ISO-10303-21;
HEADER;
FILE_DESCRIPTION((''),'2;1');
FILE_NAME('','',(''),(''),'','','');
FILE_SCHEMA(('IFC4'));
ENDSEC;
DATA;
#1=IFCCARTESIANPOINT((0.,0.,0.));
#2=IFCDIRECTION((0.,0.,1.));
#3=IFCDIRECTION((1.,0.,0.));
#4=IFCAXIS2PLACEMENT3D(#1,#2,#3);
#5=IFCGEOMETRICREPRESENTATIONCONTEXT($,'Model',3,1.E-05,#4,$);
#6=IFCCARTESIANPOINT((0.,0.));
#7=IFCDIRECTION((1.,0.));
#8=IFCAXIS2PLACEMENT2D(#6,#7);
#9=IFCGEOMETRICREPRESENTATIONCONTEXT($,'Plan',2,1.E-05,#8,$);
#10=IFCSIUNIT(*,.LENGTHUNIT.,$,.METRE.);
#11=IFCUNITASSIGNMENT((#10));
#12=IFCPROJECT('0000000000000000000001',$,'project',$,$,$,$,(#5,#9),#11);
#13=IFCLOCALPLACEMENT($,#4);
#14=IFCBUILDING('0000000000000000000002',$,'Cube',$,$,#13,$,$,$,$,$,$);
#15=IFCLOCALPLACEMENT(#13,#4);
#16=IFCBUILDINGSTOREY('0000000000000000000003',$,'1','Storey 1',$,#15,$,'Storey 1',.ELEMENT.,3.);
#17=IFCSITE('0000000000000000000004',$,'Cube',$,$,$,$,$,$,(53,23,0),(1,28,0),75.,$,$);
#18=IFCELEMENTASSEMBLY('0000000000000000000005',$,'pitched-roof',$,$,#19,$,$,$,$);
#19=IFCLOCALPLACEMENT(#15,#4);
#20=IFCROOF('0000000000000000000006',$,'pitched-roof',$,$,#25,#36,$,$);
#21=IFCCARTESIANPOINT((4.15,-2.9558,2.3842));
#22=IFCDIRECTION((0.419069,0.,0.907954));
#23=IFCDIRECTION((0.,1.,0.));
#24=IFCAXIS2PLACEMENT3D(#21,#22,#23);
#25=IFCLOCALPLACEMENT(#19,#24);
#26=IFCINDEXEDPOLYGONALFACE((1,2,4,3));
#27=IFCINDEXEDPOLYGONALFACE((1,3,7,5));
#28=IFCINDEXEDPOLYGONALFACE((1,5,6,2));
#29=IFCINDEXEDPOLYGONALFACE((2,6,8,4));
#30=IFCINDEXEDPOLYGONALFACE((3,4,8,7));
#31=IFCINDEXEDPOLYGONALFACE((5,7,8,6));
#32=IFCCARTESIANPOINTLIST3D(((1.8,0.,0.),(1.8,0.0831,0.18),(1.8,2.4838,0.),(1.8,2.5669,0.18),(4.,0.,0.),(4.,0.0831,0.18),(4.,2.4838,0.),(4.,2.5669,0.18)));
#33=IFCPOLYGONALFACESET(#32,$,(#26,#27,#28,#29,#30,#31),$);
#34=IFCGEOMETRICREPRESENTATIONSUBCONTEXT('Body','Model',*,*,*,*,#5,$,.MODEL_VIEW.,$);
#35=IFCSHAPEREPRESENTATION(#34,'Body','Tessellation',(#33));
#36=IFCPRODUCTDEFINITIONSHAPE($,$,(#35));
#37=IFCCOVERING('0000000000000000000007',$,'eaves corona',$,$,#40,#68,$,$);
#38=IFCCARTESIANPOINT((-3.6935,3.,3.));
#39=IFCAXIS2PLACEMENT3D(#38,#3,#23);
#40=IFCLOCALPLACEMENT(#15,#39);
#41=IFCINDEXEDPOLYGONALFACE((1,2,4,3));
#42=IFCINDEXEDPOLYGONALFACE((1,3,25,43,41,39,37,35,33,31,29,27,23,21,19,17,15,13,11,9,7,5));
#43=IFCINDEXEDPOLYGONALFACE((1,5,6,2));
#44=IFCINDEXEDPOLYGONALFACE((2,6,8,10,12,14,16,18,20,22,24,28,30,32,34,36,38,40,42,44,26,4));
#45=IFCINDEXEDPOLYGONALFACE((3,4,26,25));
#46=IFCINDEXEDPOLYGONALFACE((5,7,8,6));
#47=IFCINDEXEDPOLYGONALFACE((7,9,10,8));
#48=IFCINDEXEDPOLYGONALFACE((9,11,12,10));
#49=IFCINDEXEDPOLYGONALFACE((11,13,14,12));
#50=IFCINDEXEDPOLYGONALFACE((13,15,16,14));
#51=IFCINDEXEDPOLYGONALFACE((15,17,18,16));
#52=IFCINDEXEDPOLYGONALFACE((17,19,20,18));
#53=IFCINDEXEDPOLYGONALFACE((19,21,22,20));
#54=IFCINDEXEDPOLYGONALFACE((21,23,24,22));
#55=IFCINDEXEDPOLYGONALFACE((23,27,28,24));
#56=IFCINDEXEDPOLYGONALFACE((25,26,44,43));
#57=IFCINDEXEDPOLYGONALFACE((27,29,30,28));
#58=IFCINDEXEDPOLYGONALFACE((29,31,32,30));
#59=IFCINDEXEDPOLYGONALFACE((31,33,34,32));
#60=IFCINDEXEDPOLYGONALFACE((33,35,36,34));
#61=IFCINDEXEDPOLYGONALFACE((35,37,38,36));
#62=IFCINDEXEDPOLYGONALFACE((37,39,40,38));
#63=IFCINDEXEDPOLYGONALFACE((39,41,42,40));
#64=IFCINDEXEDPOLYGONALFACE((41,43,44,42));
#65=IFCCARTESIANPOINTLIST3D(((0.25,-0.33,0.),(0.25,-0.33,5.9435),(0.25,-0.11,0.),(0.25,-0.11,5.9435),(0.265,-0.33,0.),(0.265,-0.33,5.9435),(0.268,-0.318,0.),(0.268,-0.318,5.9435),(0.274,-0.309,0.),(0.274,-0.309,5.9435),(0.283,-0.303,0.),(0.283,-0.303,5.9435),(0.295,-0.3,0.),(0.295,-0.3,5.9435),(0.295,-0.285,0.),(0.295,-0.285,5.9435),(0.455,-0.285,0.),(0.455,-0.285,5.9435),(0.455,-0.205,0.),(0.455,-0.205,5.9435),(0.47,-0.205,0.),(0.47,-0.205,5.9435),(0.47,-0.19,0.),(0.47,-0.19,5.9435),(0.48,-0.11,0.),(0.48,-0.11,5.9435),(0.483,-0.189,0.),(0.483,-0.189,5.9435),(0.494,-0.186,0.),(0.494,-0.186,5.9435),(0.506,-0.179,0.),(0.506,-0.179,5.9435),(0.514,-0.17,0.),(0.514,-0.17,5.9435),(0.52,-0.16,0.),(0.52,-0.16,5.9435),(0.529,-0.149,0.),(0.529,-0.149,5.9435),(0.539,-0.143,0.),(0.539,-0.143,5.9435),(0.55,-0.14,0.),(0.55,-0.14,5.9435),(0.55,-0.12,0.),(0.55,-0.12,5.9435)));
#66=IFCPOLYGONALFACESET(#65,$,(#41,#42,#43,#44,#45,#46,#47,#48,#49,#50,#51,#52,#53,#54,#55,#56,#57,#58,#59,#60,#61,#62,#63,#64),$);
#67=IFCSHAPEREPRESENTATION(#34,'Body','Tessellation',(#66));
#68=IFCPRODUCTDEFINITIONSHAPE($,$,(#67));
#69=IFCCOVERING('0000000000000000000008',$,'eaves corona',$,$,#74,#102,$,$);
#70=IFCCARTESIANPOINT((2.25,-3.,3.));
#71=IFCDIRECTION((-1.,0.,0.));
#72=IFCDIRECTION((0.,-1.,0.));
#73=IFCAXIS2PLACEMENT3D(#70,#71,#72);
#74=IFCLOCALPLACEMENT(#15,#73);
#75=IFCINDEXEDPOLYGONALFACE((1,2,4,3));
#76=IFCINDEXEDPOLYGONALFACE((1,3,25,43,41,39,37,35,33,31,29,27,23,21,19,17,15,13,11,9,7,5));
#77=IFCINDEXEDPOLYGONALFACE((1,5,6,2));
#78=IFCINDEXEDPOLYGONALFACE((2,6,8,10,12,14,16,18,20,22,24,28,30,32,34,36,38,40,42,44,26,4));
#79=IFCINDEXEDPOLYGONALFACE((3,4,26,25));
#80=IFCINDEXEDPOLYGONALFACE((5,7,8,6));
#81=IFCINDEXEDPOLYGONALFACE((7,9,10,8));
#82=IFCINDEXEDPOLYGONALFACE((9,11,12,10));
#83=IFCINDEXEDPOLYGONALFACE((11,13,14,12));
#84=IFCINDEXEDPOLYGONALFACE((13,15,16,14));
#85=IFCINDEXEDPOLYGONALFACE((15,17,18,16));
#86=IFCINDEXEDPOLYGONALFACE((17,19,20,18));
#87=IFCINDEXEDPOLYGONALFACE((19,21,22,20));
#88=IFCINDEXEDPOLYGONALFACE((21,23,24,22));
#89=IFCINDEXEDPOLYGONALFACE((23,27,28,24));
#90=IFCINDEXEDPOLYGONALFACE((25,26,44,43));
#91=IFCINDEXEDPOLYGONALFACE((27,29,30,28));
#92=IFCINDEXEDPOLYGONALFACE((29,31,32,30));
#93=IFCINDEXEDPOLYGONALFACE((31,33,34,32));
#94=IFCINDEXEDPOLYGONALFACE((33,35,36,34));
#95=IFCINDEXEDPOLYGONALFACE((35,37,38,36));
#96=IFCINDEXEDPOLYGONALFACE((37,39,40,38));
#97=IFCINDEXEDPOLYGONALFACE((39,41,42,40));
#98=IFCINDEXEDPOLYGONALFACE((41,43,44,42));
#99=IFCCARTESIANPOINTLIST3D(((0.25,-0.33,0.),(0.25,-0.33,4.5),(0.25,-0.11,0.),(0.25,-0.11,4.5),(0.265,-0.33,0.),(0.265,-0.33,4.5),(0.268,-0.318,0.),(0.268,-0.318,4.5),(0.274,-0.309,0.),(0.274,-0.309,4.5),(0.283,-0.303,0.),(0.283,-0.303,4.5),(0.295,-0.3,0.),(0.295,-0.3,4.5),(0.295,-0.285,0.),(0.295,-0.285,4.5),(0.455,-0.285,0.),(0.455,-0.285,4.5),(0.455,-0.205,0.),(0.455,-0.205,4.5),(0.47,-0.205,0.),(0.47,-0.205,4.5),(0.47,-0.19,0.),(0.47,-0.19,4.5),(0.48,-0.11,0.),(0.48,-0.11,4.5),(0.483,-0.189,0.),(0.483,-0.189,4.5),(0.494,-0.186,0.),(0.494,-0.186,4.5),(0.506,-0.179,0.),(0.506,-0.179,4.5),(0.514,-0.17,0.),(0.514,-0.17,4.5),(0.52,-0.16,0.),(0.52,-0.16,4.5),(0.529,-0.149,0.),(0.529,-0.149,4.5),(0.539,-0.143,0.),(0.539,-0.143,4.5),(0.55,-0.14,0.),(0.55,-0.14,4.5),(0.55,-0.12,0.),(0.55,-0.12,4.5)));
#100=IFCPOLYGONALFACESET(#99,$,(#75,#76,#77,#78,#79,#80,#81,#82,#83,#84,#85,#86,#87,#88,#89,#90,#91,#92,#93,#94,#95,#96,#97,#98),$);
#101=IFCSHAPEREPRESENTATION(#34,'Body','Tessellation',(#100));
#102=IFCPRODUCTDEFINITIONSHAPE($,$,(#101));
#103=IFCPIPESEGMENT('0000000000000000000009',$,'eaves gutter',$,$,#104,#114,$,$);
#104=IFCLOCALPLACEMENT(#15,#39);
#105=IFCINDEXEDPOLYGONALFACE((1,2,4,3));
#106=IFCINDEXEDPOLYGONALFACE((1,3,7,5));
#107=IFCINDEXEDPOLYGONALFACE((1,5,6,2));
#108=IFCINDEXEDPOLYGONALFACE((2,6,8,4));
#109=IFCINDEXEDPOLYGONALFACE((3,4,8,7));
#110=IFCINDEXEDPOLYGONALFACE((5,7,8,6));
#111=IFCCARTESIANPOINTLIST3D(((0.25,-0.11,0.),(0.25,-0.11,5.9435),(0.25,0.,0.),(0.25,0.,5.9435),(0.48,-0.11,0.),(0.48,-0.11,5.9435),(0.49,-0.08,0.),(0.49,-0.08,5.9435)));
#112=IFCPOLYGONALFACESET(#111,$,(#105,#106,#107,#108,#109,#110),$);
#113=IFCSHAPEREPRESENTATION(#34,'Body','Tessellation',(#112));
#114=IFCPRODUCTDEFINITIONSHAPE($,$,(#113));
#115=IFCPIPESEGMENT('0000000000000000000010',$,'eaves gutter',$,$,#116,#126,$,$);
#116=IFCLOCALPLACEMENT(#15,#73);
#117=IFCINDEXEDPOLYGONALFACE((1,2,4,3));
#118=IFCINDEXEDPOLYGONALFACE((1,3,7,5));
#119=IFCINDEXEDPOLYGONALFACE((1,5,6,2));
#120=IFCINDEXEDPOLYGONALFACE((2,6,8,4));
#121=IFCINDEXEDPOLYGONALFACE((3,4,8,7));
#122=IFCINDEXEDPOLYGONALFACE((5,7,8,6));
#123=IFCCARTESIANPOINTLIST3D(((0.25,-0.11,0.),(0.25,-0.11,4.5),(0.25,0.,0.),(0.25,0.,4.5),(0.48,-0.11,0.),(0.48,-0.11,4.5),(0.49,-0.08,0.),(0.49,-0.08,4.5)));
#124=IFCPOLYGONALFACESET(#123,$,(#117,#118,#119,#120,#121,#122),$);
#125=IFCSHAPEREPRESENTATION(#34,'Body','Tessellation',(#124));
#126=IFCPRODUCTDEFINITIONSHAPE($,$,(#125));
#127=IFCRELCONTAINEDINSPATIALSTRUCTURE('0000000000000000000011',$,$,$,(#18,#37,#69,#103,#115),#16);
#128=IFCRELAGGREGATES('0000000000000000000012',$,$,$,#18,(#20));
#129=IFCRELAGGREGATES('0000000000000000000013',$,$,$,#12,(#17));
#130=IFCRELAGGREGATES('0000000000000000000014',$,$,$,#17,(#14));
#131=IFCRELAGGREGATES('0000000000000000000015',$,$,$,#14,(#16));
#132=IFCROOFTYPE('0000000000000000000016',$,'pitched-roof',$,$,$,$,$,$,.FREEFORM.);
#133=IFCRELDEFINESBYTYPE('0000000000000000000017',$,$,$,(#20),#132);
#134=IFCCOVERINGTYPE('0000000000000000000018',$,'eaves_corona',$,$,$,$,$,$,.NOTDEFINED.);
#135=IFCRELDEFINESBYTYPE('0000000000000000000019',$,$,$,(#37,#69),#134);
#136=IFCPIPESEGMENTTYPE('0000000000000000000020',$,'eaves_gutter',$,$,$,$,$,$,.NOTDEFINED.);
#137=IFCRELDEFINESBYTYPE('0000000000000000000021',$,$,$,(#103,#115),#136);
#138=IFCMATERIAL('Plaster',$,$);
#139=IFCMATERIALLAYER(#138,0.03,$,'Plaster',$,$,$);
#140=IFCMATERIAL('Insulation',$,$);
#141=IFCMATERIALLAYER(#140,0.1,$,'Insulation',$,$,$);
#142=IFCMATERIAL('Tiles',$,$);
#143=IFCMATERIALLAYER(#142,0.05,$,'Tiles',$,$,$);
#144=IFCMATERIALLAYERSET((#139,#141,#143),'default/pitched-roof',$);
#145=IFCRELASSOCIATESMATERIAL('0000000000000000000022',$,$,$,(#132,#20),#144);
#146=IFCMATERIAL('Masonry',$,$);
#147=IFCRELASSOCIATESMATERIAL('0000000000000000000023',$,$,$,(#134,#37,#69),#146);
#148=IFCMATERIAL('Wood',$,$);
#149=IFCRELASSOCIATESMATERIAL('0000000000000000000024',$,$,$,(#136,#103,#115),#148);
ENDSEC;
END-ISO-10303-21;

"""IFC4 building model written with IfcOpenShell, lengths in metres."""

from ifc_helpers import new_model, si_unit, frame, origin_with_axes, origin_2d_with_axis, place, context, subcontext, project, spatial, polyline, indexed_curve, outline, extrude, material, layer, layer_set, layer_usage, material_profile, profile_set, profile_usage, type_object, element, aggregate, save


model = new_model("IFC4")

# Units and contexts
model_context = context("Model", 3, precision=1e-05, world=origin_with_axes())
plan_context = context("Plan", 2, precision=1e-05, world=origin_2d_with_axis())
body_context = subcontext(model_context, "Body", "Model", "MODEL_VIEW")
ifc_project = project(units=[si_unit("LENGTHUNIT", "METRE")], contexts=[model_context, plan_context])

# Site, building, storey
site = spatial("IfcSite", under=ifc_project, Name="Cube", RefLatitude=(53, 23, 0), RefLongitude=(1, 28, 0), RefElevation=75.0)
building_placement = place(None, origin_with_axes())
building = spatial("IfcBuilding", under=site, at=building_placement, Name="Cube")
storey_placement = place(building_placement, origin_with_axes())
storey = spatial("IfcBuildingStorey", under=building, at=storey_placement, Name="1", Description="Storey 1", LongName="Storey 1", CompositionType="ELEMENT", Elevation=3.0)

# Element assembly, roof
assembly_placement = place(storey_placement, origin_with_axes())
assembly = element("IfcElementAssembly", 1, at=assembly_placement, inside=storey, Name="pitched-roof")
ifc_material_1 = material(Name="Plaster")
ifc_layer_1 = layer(ifc_material_1, 0.03, Name="Plaster")
ifc_material_2 = material(Name="Insulation")
ifc_layer_2 = layer(ifc_material_2, 0.1, Name="Insulation")
ifc_material_3 = material(Name="Tiles")
ifc_layer_3 = layer(ifc_material_3, 0.05, Name="Tiles")
ifc_layer_set = layer_set([ifc_layer_1, ifc_layer_2, ifc_layer_3], Name="default/pitched-roof")
roof_type = type_object("IfcRoofType", Name="pitched-roof", PredefinedType="FREEFORM", material=ifc_layer_set)
ifc_layer_usage_1 = layer_usage(ifc_layer_set, "AXIS3", "POSITIVE", 0.0)
roof_1_placement = place(assembly_placement, frame((4.15, -2.9558, 2.3842), z_axis=(0.419069, 0.0, 0.907954), x_axis=(0.0, 1.0, 0.0)))
roof_1 = element("IfcRoof", 2, at=roof_1_placement, type_object=roof_type, material=ifc_layer_usage_1, Name="pitched-roof", context=body_context, shape_type="SweptSolid", body=[
    extrude(outline(indexed_curve([(4.0, 2.4838), (4.0, 0.0), (1.8, 0.0), (1.8, 2.4838)])), frame((0.0, 0.0, 0.0), z_axis=(0.0, 0.0, 1.0), x_axis=(1.0, 0.0, 0.0)), (0.0, 0.419069, 0.907954), 0.1982),
])
aggregate(assembly, [roof_1])

# Coverings
ifc_material_4 = material(Name="Masonry")
ifc_material_profile_1 = material_profile(ifc_material_4, outline(polyline([(0.25, -0.11), (0.25, -0.33), (0.265, -0.33), (0.268, -0.318), (0.274, -0.309), (0.283, -0.303), (0.295, -0.3), (0.295, -0.285), (0.455, -0.285), (0.455, -0.205), (0.47, -0.205), (0.47, -0.19), (0.483, -0.189), (0.494, -0.186), (0.506, -0.179), (0.514, -0.17), (0.52, -0.16), (0.529, -0.149), (0.539, -0.143), (0.55, -0.14), (0.55, -0.12), (0.48, -0.11), (0.25, -0.11)])))
ifc_profile_set_1 = profile_set([ifc_material_profile_1])
ifc_profile_usage_1 = profile_usage(ifc_profile_set_1)
covering_type_1 = type_object("IfcCoveringType", Name="eaves_corona", PredefinedType="NOTDEFINED", material=ifc_profile_set_1)
covering_1_placement = place(storey_placement, frame((-3.6935, 3.0, 3.0), z_axis=(1.0, 0.0, 0.0), x_axis=(0.0, 1.0, 0.0)))
element("IfcCovering", 3, at=covering_1_placement, inside=storey, type_object=covering_type_1, material=ifc_profile_usage_1, Name="eaves corona", context=body_context, shape_type="SweptSolid", body=[
    extrude(outline(polyline([(0.25, -0.11), (0.25, -0.33), (0.265, -0.33), (0.268, -0.318), (0.274, -0.309), (0.283, -0.303), (0.295, -0.3), (0.295, -0.285), (0.455, -0.285), (0.455, -0.205), (0.47, -0.205), (0.47, -0.19), (0.483, -0.189), (0.494, -0.186), (0.506, -0.179), (0.514, -0.17), (0.52, -0.16), (0.529, -0.149), (0.539, -0.143), (0.55, -0.14), (0.55, -0.12), (0.48, -0.11), (0.25, -0.11)])), origin_with_axes(), (0.0, 0.0, 1.0), 5.9435),
])
ifc_profile_usage_2 = profile_usage(ifc_profile_set_1)
covering_2_placement = place(storey_placement, frame((2.25, -3.0, 3.0), z_axis=(-1.0, 0.0, 0.0), x_axis=(0.0, -1.0, 0.0)))
element("IfcCovering", 4, at=covering_2_placement, inside=storey, type_object=covering_type_1, material=ifc_profile_usage_2, Name="eaves corona", context=body_context, shape_type="SweptSolid", body=[
    extrude(outline(polyline([(0.25, -0.11), (0.25, -0.33), (0.265, -0.33), (0.268, -0.318), (0.274, -0.309), (0.283, -0.303), (0.295, -0.3), (0.295, -0.285), (0.455, -0.285), (0.455, -0.205), (0.47, -0.205), (0.47, -0.19), (0.483, -0.189), (0.494, -0.186), (0.506, -0.179), (0.514, -0.17), (0.52, -0.16), (0.529, -0.149), (0.539, -0.143), (0.55, -0.14), (0.55, -0.12), (0.48, -0.11), (0.25, -0.11)])), origin_with_axes(), (0.0, 0.0, 1.0), 4.5),
])

# Pipe segments
ifc_material_5 = material(Name="Wood")
ifc_material_profile_2 = material_profile(ifc_material_5, outline(polyline([(0.25, -0.11), (0.48, -0.11), (0.49, -0.08), (0.25, 0.0), (0.25, -0.11)])))
ifc_profile_set_2 = profile_set([ifc_material_profile_2])
ifc_profile_usage_3 = profile_usage(ifc_profile_set_2)
pipe_segment_type = type_object("IfcPipeSegmentType", Name="eaves_gutter", PredefinedType="NOTDEFINED", material=ifc_profile_set_2)
pipe_segment_1_placement = place(storey_placement, frame((-3.6935, 3.0, 3.0), z_axis=(1.0, 0.0, 0.0), x_axis=(0.0, 1.0, 0.0)))
element("IfcPipeSegment", 5, at=pipe_segment_1_placement, inside=storey, type_object=pipe_segment_type, material=ifc_profile_usage_3, Name="eaves gutter", context=body_context, shape_type="SweptSolid", body=[
    extrude(outline(polyline([(0.25, -0.11), (0.48, -0.11), (0.49, -0.08), (0.25, 0.0), (0.25, -0.11)])), origin_with_axes(), (0.0, 0.0, 1.0), 5.9435),
])
ifc_profile_usage_4 = profile_usage(ifc_profile_set_2)
pipe_segment_2_placement = place(storey_placement, frame((2.25, -3.0, 3.0), z_axis=(-1.0, 0.0, 0.0), x_axis=(0.0, -1.0, 0.0)))
element("IfcPipeSegment", 6, at=pipe_segment_2_placement, inside=storey, type_object=pipe_segment_type, material=ifc_profile_usage_4, Name="eaves gutter", context=body_context, shape_type="SweptSolid", body=[
    extrude(outline(polyline([(0.25, -0.11), (0.48, -0.11), (0.49, -0.08), (0.25, 0.0), (0.25, -0.11)])), origin_with_axes(), (0.0, 0.0, 1.0), 4.5),
])

save(model, "model.ifc")
